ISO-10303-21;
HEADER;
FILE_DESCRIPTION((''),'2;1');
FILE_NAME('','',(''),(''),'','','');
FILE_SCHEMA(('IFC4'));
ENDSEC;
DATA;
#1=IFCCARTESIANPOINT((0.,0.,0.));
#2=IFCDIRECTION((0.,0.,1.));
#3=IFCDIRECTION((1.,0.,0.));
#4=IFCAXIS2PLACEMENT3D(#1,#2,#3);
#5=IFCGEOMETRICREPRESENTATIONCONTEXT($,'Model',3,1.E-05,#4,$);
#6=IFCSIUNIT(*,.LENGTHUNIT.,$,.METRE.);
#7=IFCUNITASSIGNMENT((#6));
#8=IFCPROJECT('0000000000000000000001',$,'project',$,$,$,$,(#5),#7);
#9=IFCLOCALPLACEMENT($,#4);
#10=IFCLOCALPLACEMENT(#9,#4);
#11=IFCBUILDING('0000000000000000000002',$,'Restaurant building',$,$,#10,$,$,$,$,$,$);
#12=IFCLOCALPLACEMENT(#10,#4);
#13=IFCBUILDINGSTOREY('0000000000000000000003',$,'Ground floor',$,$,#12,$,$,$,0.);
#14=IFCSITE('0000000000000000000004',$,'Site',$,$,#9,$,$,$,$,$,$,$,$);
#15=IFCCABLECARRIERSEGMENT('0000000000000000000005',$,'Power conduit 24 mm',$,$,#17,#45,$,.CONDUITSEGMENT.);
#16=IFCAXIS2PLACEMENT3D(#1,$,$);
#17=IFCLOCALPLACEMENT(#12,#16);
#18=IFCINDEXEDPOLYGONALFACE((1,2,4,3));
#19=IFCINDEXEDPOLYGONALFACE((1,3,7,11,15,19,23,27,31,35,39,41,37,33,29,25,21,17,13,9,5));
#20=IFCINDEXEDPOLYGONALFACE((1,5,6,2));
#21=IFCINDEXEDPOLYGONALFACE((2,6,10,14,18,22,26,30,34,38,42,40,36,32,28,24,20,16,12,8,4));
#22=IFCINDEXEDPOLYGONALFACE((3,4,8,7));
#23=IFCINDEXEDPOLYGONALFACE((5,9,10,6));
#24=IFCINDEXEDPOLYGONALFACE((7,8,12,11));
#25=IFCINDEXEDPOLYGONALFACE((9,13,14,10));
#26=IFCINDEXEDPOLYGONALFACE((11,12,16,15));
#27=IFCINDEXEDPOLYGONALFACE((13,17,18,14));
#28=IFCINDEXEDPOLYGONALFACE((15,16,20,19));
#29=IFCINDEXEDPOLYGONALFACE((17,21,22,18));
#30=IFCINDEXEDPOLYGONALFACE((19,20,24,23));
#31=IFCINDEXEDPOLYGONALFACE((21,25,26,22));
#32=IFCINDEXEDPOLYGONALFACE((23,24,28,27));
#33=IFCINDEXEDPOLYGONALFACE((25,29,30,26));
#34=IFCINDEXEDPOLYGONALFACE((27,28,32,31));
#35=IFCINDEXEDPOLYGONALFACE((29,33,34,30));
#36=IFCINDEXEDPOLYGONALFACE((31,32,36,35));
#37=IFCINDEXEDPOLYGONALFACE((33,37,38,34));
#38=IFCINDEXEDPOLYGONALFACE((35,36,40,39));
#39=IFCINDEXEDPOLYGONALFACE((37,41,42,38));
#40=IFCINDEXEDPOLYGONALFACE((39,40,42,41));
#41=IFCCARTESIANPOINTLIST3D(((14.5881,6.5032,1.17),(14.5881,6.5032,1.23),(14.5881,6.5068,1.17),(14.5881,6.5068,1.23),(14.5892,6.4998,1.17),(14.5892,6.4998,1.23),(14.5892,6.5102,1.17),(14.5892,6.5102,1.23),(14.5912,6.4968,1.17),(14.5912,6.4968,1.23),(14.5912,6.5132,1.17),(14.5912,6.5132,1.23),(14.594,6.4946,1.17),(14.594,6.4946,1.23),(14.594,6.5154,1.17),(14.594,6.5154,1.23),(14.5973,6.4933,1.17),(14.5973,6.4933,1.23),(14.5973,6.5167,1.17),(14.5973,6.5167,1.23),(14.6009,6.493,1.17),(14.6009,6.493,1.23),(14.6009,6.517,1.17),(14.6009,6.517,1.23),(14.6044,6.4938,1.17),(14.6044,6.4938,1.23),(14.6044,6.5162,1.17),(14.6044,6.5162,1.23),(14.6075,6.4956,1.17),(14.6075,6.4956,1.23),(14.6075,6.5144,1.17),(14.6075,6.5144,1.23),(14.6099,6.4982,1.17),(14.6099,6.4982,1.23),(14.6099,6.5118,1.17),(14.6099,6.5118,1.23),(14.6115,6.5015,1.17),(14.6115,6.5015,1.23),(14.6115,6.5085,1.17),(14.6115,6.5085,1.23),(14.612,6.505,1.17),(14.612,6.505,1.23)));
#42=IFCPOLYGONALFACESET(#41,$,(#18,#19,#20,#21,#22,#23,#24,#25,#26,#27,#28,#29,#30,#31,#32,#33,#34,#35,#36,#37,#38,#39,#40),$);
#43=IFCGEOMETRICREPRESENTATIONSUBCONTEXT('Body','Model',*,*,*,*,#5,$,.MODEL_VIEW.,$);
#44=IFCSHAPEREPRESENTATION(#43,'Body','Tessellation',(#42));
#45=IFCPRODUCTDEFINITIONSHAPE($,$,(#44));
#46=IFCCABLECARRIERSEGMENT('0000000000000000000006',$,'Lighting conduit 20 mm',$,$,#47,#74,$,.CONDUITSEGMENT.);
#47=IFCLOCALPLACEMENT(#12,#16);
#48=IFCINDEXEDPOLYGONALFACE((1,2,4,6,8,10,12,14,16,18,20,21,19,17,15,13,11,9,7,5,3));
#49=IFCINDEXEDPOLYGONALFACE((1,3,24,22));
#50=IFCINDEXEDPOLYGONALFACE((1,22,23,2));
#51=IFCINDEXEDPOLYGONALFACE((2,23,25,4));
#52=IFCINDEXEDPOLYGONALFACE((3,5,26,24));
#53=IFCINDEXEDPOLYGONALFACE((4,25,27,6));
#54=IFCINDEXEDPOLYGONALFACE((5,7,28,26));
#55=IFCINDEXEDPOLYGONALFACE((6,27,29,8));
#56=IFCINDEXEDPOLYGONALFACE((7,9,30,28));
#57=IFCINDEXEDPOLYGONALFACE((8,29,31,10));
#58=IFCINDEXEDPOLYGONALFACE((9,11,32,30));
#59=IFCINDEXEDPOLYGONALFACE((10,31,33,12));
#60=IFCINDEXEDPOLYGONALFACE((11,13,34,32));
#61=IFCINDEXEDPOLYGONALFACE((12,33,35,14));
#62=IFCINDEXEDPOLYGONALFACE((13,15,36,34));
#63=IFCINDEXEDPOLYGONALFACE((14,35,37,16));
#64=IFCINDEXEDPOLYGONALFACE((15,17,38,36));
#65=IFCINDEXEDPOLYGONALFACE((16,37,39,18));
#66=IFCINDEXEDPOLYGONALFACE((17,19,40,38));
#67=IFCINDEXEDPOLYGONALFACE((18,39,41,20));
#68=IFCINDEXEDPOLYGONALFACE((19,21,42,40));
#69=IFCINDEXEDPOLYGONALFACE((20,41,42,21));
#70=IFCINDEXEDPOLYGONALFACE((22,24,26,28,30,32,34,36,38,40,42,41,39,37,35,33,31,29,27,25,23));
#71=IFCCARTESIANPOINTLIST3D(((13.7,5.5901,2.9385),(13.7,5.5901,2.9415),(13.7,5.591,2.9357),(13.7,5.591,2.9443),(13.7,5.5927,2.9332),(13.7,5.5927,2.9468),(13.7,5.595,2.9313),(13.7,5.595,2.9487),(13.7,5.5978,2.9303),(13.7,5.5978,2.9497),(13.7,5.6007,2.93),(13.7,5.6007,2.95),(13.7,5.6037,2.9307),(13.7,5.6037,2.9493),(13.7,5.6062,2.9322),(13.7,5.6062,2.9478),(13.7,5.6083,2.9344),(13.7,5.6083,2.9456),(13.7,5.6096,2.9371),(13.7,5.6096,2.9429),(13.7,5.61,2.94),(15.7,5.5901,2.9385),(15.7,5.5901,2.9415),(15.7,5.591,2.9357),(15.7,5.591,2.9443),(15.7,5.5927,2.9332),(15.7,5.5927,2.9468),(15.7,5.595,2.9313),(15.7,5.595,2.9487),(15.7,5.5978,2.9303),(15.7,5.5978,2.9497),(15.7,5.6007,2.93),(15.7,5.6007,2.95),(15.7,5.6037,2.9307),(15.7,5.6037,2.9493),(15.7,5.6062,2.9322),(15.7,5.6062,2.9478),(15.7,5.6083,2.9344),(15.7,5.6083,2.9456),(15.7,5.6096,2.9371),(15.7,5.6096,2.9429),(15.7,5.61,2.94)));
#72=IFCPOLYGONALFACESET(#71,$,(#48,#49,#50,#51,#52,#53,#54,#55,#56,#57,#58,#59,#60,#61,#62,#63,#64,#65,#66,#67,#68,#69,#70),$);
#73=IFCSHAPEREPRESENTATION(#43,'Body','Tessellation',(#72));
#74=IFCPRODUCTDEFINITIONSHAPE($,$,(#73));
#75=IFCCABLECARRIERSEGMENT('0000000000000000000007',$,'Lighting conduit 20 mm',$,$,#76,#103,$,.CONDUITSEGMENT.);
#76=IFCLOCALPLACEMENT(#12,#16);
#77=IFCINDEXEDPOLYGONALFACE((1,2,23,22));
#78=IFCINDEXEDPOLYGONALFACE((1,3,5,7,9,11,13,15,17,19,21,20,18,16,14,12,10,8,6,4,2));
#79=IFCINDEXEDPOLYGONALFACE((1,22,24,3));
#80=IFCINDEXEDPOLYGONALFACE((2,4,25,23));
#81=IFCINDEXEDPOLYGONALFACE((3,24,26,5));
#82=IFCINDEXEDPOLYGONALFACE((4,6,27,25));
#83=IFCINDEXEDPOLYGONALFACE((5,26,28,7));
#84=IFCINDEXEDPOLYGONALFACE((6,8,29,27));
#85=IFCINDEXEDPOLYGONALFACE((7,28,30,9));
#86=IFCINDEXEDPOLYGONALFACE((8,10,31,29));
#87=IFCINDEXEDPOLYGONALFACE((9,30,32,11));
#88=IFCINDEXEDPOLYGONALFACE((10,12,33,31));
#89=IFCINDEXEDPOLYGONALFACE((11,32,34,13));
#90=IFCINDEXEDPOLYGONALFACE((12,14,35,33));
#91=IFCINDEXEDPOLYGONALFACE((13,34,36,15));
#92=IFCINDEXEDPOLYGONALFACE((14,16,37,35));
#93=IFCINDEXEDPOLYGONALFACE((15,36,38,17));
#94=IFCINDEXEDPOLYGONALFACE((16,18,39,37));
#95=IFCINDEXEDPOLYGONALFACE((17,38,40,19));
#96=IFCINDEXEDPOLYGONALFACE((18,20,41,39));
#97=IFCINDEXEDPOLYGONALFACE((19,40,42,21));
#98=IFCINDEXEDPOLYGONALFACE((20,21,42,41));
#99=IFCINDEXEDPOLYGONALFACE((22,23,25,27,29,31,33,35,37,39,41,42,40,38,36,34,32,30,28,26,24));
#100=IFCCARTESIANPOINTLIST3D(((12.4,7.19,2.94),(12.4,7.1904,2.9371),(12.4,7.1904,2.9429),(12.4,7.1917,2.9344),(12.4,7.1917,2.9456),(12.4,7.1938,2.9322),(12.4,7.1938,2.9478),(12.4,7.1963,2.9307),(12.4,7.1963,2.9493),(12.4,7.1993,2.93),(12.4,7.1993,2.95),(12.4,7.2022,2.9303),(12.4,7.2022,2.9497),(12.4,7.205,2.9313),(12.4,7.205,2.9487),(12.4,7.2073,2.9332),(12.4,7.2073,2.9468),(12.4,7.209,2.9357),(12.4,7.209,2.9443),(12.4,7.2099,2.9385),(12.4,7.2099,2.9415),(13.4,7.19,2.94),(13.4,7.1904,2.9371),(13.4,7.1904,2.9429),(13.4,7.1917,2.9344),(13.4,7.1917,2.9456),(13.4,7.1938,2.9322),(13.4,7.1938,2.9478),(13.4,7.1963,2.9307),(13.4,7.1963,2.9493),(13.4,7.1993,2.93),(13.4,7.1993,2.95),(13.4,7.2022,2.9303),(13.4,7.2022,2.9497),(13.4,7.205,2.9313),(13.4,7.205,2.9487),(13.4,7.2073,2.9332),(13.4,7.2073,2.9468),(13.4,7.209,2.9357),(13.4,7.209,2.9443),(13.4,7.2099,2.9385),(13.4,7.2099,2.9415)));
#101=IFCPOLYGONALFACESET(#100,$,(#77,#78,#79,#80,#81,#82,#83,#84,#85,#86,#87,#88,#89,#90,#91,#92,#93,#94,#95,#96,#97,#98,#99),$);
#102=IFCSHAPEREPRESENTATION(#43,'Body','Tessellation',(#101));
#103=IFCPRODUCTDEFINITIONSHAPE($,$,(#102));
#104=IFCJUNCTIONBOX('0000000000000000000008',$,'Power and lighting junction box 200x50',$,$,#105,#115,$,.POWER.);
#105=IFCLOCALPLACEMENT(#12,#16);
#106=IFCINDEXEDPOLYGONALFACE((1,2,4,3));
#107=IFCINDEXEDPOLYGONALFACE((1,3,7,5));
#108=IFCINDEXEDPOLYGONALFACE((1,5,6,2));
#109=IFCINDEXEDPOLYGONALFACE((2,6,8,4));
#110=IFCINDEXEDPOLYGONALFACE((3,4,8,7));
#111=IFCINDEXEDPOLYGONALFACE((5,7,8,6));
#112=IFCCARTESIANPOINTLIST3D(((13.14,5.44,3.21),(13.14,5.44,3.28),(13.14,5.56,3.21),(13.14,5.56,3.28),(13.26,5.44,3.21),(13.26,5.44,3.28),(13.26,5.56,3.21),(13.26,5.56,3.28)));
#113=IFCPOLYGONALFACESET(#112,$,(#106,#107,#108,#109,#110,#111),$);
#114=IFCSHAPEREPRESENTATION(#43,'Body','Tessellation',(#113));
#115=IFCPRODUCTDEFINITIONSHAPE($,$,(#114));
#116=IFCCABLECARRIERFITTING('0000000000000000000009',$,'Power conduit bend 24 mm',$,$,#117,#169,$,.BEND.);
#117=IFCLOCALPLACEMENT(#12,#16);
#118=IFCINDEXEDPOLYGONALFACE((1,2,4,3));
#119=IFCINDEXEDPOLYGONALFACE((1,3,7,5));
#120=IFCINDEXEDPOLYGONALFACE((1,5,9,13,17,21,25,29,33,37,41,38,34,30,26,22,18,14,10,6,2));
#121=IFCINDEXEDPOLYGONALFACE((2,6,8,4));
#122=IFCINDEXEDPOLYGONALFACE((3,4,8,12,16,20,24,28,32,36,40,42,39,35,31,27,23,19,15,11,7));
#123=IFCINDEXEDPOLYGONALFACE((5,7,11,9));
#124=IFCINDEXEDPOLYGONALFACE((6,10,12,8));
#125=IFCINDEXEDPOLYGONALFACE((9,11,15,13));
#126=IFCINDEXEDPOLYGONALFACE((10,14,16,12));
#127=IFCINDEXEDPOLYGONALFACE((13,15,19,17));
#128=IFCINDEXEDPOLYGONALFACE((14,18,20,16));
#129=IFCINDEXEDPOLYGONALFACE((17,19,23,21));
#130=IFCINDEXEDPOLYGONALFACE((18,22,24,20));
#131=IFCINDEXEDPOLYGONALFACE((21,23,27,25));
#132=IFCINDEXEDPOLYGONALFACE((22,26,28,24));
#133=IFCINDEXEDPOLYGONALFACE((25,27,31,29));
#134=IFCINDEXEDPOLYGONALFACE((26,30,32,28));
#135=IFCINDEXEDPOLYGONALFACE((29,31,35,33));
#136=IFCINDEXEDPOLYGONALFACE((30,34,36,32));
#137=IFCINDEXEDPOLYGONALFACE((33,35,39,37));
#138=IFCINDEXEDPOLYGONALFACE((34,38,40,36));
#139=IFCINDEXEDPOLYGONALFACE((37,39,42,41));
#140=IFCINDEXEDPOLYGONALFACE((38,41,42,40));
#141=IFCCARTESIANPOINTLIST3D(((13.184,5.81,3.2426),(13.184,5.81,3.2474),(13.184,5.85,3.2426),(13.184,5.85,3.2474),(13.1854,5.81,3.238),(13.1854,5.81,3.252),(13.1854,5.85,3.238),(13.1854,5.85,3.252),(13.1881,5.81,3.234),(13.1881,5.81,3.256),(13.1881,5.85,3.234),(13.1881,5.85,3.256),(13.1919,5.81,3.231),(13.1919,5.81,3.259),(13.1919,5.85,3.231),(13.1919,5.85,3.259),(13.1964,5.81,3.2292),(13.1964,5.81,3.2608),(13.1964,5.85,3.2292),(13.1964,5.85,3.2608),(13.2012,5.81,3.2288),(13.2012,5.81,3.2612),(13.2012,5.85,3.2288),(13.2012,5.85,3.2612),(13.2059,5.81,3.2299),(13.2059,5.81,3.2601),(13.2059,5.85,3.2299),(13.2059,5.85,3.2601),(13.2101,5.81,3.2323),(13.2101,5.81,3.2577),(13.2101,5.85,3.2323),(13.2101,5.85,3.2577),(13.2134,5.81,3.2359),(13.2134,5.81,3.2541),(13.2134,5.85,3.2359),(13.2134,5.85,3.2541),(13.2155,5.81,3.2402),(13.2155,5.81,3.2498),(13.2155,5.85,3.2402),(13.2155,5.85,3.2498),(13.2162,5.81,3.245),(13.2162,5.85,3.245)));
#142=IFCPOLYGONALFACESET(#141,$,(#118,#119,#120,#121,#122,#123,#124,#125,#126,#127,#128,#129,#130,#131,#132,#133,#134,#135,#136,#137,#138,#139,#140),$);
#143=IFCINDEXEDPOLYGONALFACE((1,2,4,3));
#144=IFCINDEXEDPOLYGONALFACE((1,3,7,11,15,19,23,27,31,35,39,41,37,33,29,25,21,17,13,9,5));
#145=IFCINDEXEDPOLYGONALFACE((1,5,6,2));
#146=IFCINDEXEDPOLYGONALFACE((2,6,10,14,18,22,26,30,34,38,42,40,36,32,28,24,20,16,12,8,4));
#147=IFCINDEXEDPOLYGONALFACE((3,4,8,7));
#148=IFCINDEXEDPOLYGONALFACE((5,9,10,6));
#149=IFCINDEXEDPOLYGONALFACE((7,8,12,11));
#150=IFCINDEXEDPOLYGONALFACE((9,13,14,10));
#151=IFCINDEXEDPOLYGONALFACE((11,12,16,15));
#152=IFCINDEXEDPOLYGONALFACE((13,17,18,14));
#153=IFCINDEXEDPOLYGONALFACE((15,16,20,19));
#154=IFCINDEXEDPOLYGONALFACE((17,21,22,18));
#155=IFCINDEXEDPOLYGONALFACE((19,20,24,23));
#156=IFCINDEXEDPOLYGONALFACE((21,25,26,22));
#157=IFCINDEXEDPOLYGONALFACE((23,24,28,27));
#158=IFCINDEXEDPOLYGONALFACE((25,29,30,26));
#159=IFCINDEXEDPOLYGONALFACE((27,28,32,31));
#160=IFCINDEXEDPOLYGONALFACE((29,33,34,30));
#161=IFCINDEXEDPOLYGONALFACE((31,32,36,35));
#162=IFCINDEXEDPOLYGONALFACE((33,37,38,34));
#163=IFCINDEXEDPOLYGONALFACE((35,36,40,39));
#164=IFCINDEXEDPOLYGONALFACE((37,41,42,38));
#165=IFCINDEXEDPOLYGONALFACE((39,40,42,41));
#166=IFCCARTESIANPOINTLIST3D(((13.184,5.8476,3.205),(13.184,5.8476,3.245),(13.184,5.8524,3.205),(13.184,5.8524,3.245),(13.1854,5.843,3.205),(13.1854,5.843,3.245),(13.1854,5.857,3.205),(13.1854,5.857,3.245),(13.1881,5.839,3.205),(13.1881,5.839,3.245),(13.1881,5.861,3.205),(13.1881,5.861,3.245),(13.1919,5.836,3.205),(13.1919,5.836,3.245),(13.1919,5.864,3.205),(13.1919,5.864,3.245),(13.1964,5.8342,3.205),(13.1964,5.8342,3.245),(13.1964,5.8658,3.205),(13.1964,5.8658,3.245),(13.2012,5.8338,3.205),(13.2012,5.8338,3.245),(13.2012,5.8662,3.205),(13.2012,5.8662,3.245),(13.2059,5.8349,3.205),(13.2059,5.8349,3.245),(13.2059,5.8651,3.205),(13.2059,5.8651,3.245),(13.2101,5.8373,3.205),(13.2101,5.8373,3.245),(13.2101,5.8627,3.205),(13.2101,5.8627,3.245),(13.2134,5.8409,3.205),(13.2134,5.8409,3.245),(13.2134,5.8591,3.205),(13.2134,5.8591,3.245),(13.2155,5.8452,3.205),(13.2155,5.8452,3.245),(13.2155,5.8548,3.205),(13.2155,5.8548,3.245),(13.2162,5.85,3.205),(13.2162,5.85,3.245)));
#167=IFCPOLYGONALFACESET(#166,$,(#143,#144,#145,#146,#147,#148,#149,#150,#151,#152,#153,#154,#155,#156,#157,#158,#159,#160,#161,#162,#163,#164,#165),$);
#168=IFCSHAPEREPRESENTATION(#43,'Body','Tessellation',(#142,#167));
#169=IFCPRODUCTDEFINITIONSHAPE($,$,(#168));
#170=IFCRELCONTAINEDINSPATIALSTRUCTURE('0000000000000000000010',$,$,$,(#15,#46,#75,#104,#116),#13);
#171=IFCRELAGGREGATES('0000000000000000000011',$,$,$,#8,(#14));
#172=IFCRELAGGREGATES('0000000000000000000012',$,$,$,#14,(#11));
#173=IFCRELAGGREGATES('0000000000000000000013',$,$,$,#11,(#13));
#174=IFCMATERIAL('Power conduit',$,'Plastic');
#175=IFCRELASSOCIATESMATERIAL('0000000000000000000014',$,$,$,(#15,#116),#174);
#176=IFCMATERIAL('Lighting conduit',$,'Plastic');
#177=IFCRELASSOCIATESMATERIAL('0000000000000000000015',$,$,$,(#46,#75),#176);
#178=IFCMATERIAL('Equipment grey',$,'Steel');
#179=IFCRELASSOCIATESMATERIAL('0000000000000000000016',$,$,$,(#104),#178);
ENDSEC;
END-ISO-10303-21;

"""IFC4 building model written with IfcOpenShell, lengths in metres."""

from ifc_helpers import new_model, si_unit, frame, origin, origin_with_axes, origin_2d, place, context, subcontext, project, spatial, rectangle, circle, extrude, material, element, save


model = new_model("IFC4")

# Units and contexts
model_context = context("Model", 3, precision=1e-05, world=origin_with_axes())
body_context = subcontext(model_context, "Body", "Model", "MODEL_VIEW")
ifc_project = project(units=[si_unit("LENGTHUNIT", "METRE")], contexts=[model_context])

# Site, building, storey
site_placement = place(None, origin_with_axes())
site = spatial("IfcSite", under=ifc_project, at=site_placement, Name="Site")
building_placement = place(site_placement, origin_with_axes())
building = spatial("IfcBuilding", under=site, at=building_placement, Name="Restaurant building")
storey_placement = place(building_placement, origin_with_axes())
storey = spatial("IfcBuildingStorey", under=building, at=storey_placement, Name="Ground floor", Elevation=0.0)

# Cable carrier segments
ifc_material_1 = material(Name="Power conduit", Category="Plastic")
cable_carrier_segment_1_placement = place(storey_placement, frame((14.6, 6.505, 1.17)))
element("IfcCableCarrierSegment", 1, at=cable_carrier_segment_1_placement, inside=storey, material=ifc_material_1, Name="Power conduit 24 mm", PredefinedType="CONDUITSEGMENT", context=body_context, shape_type="SweptSolid", body=[
    extrude(circle(Radius=0.012, at=origin_2d()), origin(), (0.0, 0.0, 1.0), 0.06),
])
ifc_material_2 = material(Name="Lighting conduit", Category="Plastic")
cable_carrier_segment_2_placement = place(storey_placement, frame((13.7, 5.6, 2.94)))
element("IfcCableCarrierSegment", 2, at=cable_carrier_segment_2_placement, inside=storey, material=ifc_material_2, Name="Lighting conduit 20 mm", PredefinedType="CONDUITSEGMENT", context=body_context, shape_type="SweptSolid", body=[
    extrude(circle(Radius=0.01, at=origin_2d()), frame((0.0, 0.0, 0.0), z_axis=(1.0, 0.0, 0.0), x_axis=(0.0, 1.0, 0.0)), (0.0, 0.0, 1.0), 2.0),
])
cable_carrier_segment_3_placement = place(storey_placement, frame((13.4, 7.2, 2.94)))
element("IfcCableCarrierSegment", 3, at=cable_carrier_segment_3_placement, inside=storey, material=ifc_material_2, Name="Lighting conduit 20 mm", PredefinedType="CONDUITSEGMENT", context=body_context, shape_type="SweptSolid", body=[
    extrude(circle(Radius=0.01, at=origin_2d()), frame((0.0, 0.0, 0.0), z_axis=(-1.0, 0.0, 0.0), x_axis=(0.0, -1.0, 0.0)), (0.0, 0.0, 1.0), 1.0),
])

# Junction box
ifc_material_3 = material(Name="Equipment grey", Category="Steel")
junction_box_placement = place(storey_placement, frame((13.2, 5.5, 3.245)))
element("IfcJunctionBox", 4, at=junction_box_placement, inside=storey, material=ifc_material_3, Name="Power and lighting junction box 200x50", PredefinedType="POWER", context=body_context, shape_type="SweptSolid", body=[
    extrude(rectangle(XDim=0.12, YDim=0.12, at=origin_2d()), frame((0.0, 0.0, -0.035)), (0.0, 0.0, 1.0), 0.07),
])

# Cable carrier fitting
cable_carrier_fitting_1_placement = place(storey_placement, frame((13.2, 5.85, 3.245)))
element("IfcCableCarrierFitting", 5, at=cable_carrier_fitting_1_placement, inside=storey, material=ifc_material_1, Name="Power conduit bend 24 mm", PredefinedType="BEND", context=body_context, shape_type="SweptSolid", body=[
    extrude(circle(Radius=0.0162, at=origin_2d()), frame((0.0, 0.0, 0.0), z_axis=(0.0, -1.0, 0.0), x_axis=(1.0, 0.0, 0.0)), (0.0, 0.0, 1.0), 0.04),
    extrude(circle(Radius=0.0162, at=origin_2d()), frame((0.0, 0.0, 0.0), z_axis=(0.0, 0.0, -1.0), x_axis=(1.0, 0.0, 0.0)), (0.0, 0.0, 1.0), 0.04),
])

save(model, "model.ifc")
